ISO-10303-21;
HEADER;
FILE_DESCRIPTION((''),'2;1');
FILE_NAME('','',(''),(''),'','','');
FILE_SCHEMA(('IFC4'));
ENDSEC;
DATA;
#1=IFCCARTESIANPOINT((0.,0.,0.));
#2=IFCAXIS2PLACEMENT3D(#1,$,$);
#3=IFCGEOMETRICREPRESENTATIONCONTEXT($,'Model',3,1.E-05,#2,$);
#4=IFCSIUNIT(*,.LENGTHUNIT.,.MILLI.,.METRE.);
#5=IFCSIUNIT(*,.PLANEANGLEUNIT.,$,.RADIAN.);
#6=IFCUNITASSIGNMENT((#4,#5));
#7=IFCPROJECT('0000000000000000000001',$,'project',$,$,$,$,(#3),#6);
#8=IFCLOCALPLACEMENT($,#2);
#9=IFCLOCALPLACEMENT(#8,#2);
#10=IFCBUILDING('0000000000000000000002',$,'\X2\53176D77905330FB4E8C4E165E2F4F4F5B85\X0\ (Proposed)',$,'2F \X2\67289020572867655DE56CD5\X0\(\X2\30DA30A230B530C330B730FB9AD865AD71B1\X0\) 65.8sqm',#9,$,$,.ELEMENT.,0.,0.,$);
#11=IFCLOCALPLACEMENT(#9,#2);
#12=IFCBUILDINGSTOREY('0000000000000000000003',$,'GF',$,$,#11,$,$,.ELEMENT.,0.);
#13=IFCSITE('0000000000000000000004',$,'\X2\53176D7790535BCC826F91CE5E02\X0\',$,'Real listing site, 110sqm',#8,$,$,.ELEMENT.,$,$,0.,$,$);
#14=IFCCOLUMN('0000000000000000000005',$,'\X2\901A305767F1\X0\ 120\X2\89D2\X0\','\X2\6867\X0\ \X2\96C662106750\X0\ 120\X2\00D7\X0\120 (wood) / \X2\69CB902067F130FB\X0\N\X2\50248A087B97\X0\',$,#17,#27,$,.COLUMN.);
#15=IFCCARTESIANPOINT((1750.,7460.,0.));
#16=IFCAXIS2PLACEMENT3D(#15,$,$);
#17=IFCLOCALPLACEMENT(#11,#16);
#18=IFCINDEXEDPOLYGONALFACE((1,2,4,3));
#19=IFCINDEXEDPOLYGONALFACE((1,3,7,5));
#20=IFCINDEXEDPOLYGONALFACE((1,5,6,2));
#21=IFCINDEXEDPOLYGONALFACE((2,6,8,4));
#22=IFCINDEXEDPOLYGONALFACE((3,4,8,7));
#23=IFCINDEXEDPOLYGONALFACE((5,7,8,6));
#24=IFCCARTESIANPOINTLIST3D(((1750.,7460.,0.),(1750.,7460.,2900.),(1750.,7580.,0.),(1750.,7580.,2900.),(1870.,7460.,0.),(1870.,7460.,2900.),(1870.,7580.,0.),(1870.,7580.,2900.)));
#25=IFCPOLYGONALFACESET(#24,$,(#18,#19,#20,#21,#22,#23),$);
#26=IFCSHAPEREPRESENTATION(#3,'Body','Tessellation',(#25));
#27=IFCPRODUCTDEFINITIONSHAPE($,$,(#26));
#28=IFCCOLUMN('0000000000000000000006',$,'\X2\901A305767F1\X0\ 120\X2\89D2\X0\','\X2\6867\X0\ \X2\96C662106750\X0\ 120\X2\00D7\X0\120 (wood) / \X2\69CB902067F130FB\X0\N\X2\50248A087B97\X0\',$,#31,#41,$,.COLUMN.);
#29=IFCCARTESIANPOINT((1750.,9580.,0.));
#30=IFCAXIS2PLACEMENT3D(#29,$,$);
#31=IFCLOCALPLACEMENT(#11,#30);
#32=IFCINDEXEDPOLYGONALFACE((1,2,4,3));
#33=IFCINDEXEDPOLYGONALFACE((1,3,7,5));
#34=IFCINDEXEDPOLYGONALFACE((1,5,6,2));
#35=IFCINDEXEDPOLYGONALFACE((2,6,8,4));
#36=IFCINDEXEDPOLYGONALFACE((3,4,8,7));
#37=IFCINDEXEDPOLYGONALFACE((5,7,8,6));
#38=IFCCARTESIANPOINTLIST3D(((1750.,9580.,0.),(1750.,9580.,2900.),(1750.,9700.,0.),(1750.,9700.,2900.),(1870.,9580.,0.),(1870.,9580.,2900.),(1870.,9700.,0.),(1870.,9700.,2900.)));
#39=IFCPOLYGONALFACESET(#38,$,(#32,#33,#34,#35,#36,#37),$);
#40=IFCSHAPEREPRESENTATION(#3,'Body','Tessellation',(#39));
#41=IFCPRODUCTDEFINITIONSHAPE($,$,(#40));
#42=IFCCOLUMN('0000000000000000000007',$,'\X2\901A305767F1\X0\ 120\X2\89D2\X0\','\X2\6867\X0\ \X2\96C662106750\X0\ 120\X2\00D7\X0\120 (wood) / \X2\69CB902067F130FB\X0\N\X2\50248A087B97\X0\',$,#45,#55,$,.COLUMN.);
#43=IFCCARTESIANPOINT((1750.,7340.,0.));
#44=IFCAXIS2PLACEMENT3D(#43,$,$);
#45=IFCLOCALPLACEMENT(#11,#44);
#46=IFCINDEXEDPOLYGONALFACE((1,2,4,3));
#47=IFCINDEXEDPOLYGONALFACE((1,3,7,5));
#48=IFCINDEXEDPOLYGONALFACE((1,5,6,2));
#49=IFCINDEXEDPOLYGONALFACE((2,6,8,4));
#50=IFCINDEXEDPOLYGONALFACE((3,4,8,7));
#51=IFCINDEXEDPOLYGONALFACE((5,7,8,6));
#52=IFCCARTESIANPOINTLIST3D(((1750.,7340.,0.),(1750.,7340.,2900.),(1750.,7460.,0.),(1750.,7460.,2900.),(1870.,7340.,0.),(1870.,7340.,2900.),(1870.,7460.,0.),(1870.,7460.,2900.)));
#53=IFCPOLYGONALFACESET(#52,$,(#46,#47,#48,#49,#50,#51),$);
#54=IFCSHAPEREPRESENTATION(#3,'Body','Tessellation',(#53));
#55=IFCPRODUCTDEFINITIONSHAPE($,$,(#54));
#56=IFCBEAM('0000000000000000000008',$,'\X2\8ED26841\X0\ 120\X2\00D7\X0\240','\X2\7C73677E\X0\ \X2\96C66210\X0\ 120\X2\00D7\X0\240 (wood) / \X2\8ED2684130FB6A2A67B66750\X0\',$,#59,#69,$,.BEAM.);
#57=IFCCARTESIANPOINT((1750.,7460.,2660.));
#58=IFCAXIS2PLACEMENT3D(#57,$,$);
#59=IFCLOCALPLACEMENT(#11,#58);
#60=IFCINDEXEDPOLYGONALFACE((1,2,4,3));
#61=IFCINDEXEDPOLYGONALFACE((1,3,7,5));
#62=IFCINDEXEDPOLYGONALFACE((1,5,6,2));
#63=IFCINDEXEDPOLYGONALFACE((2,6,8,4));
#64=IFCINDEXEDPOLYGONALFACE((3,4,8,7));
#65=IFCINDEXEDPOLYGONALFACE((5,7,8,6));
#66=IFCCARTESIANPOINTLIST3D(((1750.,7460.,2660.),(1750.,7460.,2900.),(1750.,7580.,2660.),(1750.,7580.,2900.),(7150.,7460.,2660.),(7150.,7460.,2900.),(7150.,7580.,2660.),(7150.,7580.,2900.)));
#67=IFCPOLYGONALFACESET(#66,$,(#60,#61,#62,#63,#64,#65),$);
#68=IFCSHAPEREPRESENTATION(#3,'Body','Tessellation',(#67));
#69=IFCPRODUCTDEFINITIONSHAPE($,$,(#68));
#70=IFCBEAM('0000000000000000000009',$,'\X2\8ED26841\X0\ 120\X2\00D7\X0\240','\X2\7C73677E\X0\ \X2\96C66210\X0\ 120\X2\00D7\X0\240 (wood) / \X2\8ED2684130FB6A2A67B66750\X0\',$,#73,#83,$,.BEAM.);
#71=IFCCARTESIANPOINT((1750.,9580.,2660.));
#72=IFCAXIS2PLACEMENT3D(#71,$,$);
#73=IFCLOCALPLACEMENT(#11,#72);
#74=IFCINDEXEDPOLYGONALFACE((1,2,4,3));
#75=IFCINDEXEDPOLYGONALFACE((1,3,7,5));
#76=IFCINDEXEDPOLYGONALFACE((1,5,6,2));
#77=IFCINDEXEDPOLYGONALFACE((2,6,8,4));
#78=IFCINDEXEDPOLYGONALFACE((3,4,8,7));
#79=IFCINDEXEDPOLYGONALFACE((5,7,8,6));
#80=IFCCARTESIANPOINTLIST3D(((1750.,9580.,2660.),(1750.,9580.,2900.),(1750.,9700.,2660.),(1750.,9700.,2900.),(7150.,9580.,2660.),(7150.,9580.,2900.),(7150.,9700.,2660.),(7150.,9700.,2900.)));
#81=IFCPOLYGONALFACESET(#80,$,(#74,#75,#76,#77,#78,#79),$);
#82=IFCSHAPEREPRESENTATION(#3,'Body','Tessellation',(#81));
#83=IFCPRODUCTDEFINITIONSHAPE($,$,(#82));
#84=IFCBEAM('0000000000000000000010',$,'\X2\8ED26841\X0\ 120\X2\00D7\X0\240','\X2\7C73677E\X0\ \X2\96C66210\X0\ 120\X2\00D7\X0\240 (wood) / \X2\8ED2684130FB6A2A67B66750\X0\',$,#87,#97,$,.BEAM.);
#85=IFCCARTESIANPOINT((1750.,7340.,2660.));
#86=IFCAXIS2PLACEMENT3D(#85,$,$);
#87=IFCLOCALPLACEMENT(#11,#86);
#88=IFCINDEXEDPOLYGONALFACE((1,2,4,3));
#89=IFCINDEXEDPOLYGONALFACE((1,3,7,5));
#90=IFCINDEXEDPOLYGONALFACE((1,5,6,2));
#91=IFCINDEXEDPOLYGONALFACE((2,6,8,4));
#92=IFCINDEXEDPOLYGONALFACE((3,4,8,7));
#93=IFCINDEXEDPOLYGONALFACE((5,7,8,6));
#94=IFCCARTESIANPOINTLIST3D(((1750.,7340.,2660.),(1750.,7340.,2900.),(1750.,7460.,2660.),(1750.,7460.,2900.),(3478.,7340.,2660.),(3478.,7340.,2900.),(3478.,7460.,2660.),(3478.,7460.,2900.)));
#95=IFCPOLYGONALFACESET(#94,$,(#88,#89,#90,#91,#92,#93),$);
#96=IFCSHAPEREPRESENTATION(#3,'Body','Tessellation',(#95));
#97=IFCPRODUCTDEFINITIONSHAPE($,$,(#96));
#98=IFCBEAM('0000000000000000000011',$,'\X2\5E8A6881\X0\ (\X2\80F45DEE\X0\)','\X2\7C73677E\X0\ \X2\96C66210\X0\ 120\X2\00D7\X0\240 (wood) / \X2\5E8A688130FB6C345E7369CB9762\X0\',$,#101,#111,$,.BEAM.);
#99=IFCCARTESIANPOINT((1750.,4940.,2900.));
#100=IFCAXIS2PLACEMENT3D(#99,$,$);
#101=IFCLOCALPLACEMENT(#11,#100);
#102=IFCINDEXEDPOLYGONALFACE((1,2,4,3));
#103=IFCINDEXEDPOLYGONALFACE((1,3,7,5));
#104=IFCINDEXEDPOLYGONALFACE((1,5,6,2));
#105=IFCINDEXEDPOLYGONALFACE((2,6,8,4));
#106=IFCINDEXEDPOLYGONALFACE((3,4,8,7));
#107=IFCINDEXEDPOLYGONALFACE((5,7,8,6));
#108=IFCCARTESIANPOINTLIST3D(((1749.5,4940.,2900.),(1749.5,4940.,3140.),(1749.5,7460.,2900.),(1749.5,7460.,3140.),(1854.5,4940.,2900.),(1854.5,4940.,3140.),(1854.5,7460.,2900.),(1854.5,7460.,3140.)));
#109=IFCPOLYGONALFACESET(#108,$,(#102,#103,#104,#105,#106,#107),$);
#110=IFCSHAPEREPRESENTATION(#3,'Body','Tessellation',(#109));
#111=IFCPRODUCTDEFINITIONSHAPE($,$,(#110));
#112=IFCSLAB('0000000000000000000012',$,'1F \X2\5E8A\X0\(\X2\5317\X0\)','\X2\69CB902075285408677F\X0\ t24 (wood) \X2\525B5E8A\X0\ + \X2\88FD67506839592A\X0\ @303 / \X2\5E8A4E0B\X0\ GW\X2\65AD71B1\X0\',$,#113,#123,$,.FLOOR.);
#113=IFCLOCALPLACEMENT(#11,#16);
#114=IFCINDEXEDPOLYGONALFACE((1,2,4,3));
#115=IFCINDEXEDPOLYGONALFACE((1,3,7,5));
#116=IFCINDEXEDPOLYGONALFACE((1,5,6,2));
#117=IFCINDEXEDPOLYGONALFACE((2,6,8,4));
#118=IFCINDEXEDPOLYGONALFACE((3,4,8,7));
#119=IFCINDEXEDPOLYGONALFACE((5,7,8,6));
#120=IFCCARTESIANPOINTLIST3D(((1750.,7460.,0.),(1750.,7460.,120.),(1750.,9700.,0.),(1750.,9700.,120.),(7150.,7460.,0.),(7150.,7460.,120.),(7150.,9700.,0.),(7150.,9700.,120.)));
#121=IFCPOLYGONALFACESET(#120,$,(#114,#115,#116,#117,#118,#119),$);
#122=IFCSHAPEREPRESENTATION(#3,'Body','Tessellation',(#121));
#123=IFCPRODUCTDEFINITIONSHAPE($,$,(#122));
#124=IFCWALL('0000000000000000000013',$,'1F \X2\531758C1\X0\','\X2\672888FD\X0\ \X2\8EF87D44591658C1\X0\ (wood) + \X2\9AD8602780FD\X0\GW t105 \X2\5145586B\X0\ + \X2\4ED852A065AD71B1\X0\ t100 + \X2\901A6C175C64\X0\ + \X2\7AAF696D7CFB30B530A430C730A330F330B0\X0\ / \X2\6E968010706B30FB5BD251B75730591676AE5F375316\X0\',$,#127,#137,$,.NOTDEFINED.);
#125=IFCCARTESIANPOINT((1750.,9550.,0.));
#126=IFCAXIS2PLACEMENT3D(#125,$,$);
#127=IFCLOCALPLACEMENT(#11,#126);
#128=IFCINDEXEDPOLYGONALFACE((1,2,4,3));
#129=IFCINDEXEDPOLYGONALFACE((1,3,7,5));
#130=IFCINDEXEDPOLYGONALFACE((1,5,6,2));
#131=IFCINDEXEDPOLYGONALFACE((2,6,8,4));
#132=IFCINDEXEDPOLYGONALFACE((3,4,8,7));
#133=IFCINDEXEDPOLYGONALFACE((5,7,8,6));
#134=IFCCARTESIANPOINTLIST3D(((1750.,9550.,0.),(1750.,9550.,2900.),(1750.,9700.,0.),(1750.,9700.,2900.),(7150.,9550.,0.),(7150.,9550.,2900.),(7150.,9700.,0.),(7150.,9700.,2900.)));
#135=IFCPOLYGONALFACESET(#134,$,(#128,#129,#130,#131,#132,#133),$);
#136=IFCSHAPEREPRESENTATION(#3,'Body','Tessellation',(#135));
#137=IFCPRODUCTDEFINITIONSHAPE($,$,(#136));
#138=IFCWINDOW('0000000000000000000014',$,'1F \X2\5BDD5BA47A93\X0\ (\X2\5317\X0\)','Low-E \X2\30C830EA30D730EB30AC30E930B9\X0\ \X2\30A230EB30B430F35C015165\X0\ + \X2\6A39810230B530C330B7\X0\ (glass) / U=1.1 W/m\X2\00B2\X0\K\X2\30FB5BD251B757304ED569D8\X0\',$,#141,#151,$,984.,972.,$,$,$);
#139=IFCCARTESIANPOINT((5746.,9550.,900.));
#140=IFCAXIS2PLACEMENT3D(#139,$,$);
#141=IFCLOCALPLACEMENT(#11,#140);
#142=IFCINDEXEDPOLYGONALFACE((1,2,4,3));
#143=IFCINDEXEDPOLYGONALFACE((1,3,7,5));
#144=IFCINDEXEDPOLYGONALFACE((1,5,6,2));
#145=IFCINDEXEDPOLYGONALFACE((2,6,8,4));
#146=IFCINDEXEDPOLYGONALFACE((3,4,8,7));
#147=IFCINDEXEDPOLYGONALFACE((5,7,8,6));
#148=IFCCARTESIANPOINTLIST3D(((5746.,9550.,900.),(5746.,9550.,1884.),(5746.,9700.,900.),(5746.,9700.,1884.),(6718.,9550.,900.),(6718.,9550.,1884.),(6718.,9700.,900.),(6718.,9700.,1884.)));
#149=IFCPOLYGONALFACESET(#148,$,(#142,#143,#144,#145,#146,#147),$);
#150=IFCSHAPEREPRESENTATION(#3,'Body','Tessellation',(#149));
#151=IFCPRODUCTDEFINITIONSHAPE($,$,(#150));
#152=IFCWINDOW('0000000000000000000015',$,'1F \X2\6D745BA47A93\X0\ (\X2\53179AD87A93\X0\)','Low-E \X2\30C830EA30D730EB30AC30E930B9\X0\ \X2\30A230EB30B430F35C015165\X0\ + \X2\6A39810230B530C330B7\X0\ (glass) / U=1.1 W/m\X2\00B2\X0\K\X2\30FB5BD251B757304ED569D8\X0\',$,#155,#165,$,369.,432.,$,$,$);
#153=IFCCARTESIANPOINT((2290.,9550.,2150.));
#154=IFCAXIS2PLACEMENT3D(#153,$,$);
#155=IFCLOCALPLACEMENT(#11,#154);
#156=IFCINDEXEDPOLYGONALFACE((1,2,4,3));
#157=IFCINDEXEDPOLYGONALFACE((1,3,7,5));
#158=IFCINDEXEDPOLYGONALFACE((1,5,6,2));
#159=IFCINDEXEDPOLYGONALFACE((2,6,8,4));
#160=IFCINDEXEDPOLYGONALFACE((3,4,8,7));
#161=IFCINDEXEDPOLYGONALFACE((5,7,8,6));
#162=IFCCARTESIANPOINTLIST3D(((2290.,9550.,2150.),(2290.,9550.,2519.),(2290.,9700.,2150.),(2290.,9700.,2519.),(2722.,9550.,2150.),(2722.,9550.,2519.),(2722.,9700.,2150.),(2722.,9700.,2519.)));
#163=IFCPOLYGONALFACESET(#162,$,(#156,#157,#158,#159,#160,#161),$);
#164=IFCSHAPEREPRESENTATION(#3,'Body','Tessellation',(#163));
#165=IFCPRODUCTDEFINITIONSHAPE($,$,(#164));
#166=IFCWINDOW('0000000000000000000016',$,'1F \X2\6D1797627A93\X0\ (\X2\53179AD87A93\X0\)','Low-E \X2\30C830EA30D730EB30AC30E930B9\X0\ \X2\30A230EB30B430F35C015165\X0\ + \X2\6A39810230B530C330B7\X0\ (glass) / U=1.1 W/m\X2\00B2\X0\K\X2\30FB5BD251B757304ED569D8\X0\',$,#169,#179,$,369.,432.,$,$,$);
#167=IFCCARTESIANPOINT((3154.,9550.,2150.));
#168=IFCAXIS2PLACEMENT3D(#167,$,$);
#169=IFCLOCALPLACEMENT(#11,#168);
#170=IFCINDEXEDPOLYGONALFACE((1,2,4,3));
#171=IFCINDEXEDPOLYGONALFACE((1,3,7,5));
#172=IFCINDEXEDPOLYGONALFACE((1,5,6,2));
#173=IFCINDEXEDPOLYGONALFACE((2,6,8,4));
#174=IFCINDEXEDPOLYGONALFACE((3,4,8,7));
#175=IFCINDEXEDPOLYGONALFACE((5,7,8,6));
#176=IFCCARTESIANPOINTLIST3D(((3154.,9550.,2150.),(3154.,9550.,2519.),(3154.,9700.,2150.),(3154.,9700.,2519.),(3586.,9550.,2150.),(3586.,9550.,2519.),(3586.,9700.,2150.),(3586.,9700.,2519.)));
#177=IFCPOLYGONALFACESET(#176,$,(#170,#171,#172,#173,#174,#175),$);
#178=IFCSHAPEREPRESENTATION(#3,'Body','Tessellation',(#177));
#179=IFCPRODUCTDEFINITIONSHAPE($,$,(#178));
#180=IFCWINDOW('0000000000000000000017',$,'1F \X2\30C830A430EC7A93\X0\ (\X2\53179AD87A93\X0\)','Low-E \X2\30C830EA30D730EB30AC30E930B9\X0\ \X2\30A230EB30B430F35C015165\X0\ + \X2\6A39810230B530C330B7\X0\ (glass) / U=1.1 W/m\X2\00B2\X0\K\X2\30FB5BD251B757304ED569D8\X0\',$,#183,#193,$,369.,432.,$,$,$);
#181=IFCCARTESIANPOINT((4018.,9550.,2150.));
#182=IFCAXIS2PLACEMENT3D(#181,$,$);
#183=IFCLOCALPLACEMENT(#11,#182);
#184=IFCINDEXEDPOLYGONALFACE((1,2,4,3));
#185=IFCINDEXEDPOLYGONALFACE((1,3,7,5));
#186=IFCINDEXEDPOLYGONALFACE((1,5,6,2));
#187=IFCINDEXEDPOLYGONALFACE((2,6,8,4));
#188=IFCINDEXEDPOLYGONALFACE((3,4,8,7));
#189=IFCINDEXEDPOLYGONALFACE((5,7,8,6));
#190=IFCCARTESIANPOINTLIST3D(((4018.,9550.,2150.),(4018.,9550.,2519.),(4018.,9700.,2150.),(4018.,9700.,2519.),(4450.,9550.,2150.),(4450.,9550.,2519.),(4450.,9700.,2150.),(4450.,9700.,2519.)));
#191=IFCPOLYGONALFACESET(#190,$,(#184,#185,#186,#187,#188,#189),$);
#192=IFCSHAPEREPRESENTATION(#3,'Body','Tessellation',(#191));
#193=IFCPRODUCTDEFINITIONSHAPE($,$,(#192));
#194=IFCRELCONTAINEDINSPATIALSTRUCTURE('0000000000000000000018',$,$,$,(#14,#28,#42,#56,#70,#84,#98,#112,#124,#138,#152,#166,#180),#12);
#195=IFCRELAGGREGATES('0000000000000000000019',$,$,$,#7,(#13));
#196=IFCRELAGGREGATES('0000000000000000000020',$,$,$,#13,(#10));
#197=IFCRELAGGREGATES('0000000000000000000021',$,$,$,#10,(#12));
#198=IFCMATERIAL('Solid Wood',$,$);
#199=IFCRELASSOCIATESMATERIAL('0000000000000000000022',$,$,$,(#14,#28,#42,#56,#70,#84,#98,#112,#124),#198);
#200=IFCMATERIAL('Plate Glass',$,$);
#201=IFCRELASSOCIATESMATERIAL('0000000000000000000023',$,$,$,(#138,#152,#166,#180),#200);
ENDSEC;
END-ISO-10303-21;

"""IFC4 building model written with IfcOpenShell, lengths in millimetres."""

from ifc_helpers import new_model, si_unit, frame, frame_2d, origin, place, context, project, spatial, rectangle, extrude, material, element, fill, save


model = new_model("IFC4")

# Units and contexts
model_context = context("Model", 3, precision=1e-05, world=origin())
ifc_project = project(units=[si_unit("LENGTHUNIT", "METRE", prefix="MILLI"), si_unit("PLANEANGLEUNIT", "RADIAN")], contexts=[model_context])

# Site, building, storey
site_placement = place(None, origin())
site = spatial("IfcSite", under=ifc_project, at=site_placement, Name="北海道富良野市", ObjectType="Real listing site, 110sqm", CompositionType="ELEMENT", RefElevation=0.0)
building_placement = place(site_placement, origin())
building = spatial("IfcBuilding", under=site, at=building_placement, Name="北海道・二世帯住宅 (Proposed)", ObjectType="2F 木造在来工法(ペアサッシ・高断熱) 65.8sqm", CompositionType="ELEMENT", ElevationOfRefHeight=0.0, ElevationOfTerrain=0.0)
storey_placement = place(building_placement, origin())
storey = spatial("IfcBuildingStorey", under=building, at=storey_placement, Name="GF", CompositionType="ELEMENT", Elevation=0.0)

# Columns
ifc_material_1 = material(Name="Solid Wood")
column_1_placement = place(storey_placement, frame((1750.0, 7460.0, 0.0)))
element("IfcColumn", 1, at=column_1_placement, inside=storey, material=ifc_material_1, Name="通し柱 120角", Description="桧 集成材 120×120 (wood) / 構造柱・N値計算", PredefinedType="COLUMN", context=model_context, shape_type="SweptSolid", body=[
    extrude(rectangle(XDim=120.0, YDim=120.0, at=frame_2d((60.0, 60.0))), frame((1750.0, 7460.0, 0.0)), (0.0, 0.0, 1.0), 2900.0),
])
column_2_placement = place(storey_placement, frame((1750.0, 9580.0, 0.0)))
element("IfcColumn", 2, at=column_2_placement, inside=storey, material=ifc_material_1, Name="通し柱 120角", Description="桧 集成材 120×120 (wood) / 構造柱・N値計算", PredefinedType="COLUMN", context=model_context, shape_type="SweptSolid", body=[
    extrude(rectangle(XDim=120.0, YDim=120.0, at=frame_2d((60.0, 60.0))), frame((1750.0, 9580.0, 0.0)), (0.0, 0.0, 1.0), 2900.0),
])
column_3_placement = place(storey_placement, frame((1750.0, 7340.0, 0.0)))
element("IfcColumn", 3, at=column_3_placement, inside=storey, material=ifc_material_1, Name="通し柱 120角", Description="桧 集成材 120×120 (wood) / 構造柱・N値計算", PredefinedType="COLUMN", context=model_context, shape_type="SweptSolid", body=[
    extrude(rectangle(XDim=120.0, YDim=120.0, at=frame_2d((60.0, 60.0))), frame((1750.0, 7340.0, 0.0)), (0.0, 0.0, 1.0), 2900.0),
])

# Beams
beam_1_placement = place(storey_placement, frame((1750.0, 7460.0, 2660.0)))
element("IfcBeam", 4, at=beam_1_placement, inside=storey, material=ifc_material_1, Name="軒桁 120×240", Description="米松 集成 120×240 (wood) / 軒桁・横架材", PredefinedType="BEAM", context=model_context, shape_type="SweptSolid", body=[
    extrude(rectangle(XDim=5400.0, YDim=120.0, at=frame_2d((2700.0, 60.0))), frame((1750.0, 7460.0, 2660.0)), (0.0, 0.0, 1.0), 240.0),
])
beam_2_placement = place(storey_placement, frame((1750.0, 9580.0, 2660.0)))
element("IfcBeam", 5, at=beam_2_placement, inside=storey, material=ifc_material_1, Name="軒桁 120×240", Description="米松 集成 120×240 (wood) / 軒桁・横架材", PredefinedType="BEAM", context=model_context, shape_type="SweptSolid", body=[
    extrude(rectangle(XDim=5400.0, YDim=120.0, at=frame_2d((2700.0, 60.0))), frame((1750.0, 9580.0, 2660.0)), (0.0, 0.0, 1.0), 240.0),
])
beam_3_placement = place(storey_placement, frame((1750.0, 7340.0, 2660.0)))
element("IfcBeam", 6, at=beam_3_placement, inside=storey, material=ifc_material_1, Name="軒桁 120×240", Description="米松 集成 120×240 (wood) / 軒桁・横架材", PredefinedType="BEAM", context=model_context, shape_type="SweptSolid", body=[
    extrude(rectangle(XDim=1728.0, YDim=120.0, at=frame_2d((864.0, 60.0))), frame((1750.0, 7340.0, 2660.0)), (0.0, 0.0, 1.0), 240.0),
])
beam_4_placement = place(storey_placement, frame((1750.0, 4940.0, 2900.0)))
element("IfcBeam", 7, at=beam_4_placement, inside=storey, material=ifc_material_1, Name="床梁 (胴差)", Description="米松 集成 120×240 (wood) / 床梁・水平構面", PredefinedType="BEAM", context=model_context, shape_type="SweptSolid", body=[
    extrude(rectangle(XDim=105.0, YDim=2520.0, at=frame_2d((52.0, 1260.0))), frame((1750.0, 4940.0, 2900.0)), (0.0, 0.0, 1.0), 240.0),
])

# Slab
slab_placement = place(storey_placement, frame((1750.0, 7460.0, 0.0)))
element("IfcSlab", 8, at=slab_placement, inside=storey, material=ifc_material_1, Name="1F 床(北)", Description="構造用合板 t24 (wood) 剛床 + 製材根太 @303 / 床下 GW断熱", PredefinedType="FLOOR", context=model_context, shape_type="SweptSolid", body=[
    extrude(rectangle(XDim=5400.0, YDim=2240.0, at=frame_2d((2700.0, 1120.0))), frame((1750.0, 7460.0, 0.0)), (0.0, 0.0, 1.0), 120.0),
])

# Wall, openings, windows
wall_1_placement = place(storey_placement, frame((1750.0, 9550.0, 0.0)))
wall_1 = element("IfcWall", 9, at=wall_1_placement, inside=storey, material=ifc_material_1, Name="1F 北壁", Description="木製 軸組外壁 (wood) + 高性能GW t105 充填 + 付加断熱 t100 + 通気層 + 窯業系サイディング / 準耐火・寒冷地外皮強化", PredefinedType="NOTDEFINED", context=model_context, shape_type="SweptSolid", body=[
    extrude(rectangle(XDim=5400.0, YDim=150.0, at=frame_2d((2700.0, 75.0))), frame((1750.0, 9550.0, 0.0)), (0.0, 0.0, 1.0), 2900.0),
])
opening_1_placement = place(storey_placement, frame((5746.0, 9550.0, 900.0)))
opening_1 = element("IfcOpeningElement", 10, at=opening_1_placement, cuts=wall_1, PredefinedType="NOTDEFINED", context=model_context, shape_type="SweptSolid", body=[
    extrude(rectangle(XDim=972.0, YDim=150.0, at=frame_2d((486.0, 75.0))), frame((5746.0, 9550.0, 900.0)), (0.0, 0.0, 1.0), 984.0),
])
opening_2_placement = place(storey_placement, frame((2290.0, 9550.0, 2150.0)))
opening_2 = element("IfcOpeningElement", 11, at=opening_2_placement, cuts=wall_1, PredefinedType="NOTDEFINED", context=model_context, shape_type="SweptSolid", body=[
    extrude(rectangle(XDim=432.0, YDim=150.0, at=frame_2d((216.0, 75.0))), frame((2290.0, 9550.0, 2150.0)), (0.0, 0.0, 1.0), 369.0),
])
opening_3_placement = place(storey_placement, frame((3154.0, 9550.0, 2150.0)))
opening_3 = element("IfcOpeningElement", 12, at=opening_3_placement, cuts=wall_1, PredefinedType="NOTDEFINED", context=model_context, shape_type="SweptSolid", body=[
    extrude(rectangle(XDim=432.0, YDim=150.0, at=frame_2d((216.0, 75.0))), frame((3154.0, 9550.0, 2150.0)), (0.0, 0.0, 1.0), 369.0),
])
opening_4_placement = place(storey_placement, frame((4018.0, 9550.0, 2150.0)))
opening_4 = element("IfcOpeningElement", 13, at=opening_4_placement, cuts=wall_1, PredefinedType="NOTDEFINED", context=model_context, shape_type="SweptSolid", body=[
    extrude(rectangle(XDim=432.0, YDim=150.0, at=frame_2d((216.0, 75.0))), frame((4018.0, 9550.0, 2150.0)), (0.0, 0.0, 1.0), 369.0),
])
ifc_material_2 = material(Name="Plate Glass")
window_1_placement = place(storey_placement, frame((5746.0, 9550.0, 900.0)))
window_1 = element("IfcWindow", 14, at=window_1_placement, inside=storey, material=ifc_material_2, Name="1F 寝室窓 (北)", Description="Low-E トリプルガラス アルゴン封入 + 樹脂サッシ (glass) / U=1.1 W/m²K・寒冷地仕様", OverallHeight=984.0, OverallWidth=972.0, context=model_context, shape_type="SweptSolid", body=[
    extrude(rectangle(XDim=972.0, YDim=150.0, at=frame_2d((486.0, 75.0))), frame((5746.0, 9550.0, 900.0)), (0.0, 0.0, 1.0), 984.0),
])
fill(opening_1, window_1)
window_2_placement = place(storey_placement, frame((2290.0, 9550.0, 2150.0)))
window_2 = element("IfcWindow", 15, at=window_2_placement, inside=storey, material=ifc_material_2, Name="1F 浴室窓 (北高窓)", Description="Low-E トリプルガラス アルゴン封入 + 樹脂サッシ (glass) / U=1.1 W/m²K・寒冷地仕様", OverallHeight=369.0, OverallWidth=432.0, context=model_context, shape_type="SweptSolid", body=[
    extrude(rectangle(XDim=432.0, YDim=150.0, at=frame_2d((216.0, 75.0))), frame((2290.0, 9550.0, 2150.0)), (0.0, 0.0, 1.0), 369.0),
])
fill(opening_2, window_2)
window_3_placement = place(storey_placement, frame((3154.0, 9550.0, 2150.0)))
window_3 = element("IfcWindow", 16, at=window_3_placement, inside=storey, material=ifc_material_2, Name="1F 洗面窓 (北高窓)", Description="Low-E トリプルガラス アルゴン封入 + 樹脂サッシ (glass) / U=1.1 W/m²K・寒冷地仕様", OverallHeight=369.0, OverallWidth=432.0, context=model_context, shape_type="SweptSolid", body=[
    extrude(rectangle(XDim=432.0, YDim=150.0, at=frame_2d((216.0, 75.0))), frame((3154.0, 9550.0, 2150.0)), (0.0, 0.0, 1.0), 369.0),
])
fill(opening_3, window_3)
window_4_placement = place(storey_placement, frame((4018.0, 9550.0, 2150.0)))
window_4 = element("IfcWindow", 17, at=window_4_placement, inside=storey, material=ifc_material_2, Name="1F トイレ窓 (北高窓)", Description="Low-E トリプルガラス アルゴン封入 + 樹脂サッシ (glass) / U=1.1 W/m²K・寒冷地仕様", OverallHeight=369.0, OverallWidth=432.0, context=model_context, shape_type="SweptSolid", body=[
    extrude(rectangle(XDim=432.0, YDim=150.0, at=frame_2d((216.0, 75.0))), frame((4018.0, 9550.0, 2150.0)), (0.0, 0.0, 1.0), 369.0),
])
fill(opening_4, window_4)

save(model, "model.ifc")
